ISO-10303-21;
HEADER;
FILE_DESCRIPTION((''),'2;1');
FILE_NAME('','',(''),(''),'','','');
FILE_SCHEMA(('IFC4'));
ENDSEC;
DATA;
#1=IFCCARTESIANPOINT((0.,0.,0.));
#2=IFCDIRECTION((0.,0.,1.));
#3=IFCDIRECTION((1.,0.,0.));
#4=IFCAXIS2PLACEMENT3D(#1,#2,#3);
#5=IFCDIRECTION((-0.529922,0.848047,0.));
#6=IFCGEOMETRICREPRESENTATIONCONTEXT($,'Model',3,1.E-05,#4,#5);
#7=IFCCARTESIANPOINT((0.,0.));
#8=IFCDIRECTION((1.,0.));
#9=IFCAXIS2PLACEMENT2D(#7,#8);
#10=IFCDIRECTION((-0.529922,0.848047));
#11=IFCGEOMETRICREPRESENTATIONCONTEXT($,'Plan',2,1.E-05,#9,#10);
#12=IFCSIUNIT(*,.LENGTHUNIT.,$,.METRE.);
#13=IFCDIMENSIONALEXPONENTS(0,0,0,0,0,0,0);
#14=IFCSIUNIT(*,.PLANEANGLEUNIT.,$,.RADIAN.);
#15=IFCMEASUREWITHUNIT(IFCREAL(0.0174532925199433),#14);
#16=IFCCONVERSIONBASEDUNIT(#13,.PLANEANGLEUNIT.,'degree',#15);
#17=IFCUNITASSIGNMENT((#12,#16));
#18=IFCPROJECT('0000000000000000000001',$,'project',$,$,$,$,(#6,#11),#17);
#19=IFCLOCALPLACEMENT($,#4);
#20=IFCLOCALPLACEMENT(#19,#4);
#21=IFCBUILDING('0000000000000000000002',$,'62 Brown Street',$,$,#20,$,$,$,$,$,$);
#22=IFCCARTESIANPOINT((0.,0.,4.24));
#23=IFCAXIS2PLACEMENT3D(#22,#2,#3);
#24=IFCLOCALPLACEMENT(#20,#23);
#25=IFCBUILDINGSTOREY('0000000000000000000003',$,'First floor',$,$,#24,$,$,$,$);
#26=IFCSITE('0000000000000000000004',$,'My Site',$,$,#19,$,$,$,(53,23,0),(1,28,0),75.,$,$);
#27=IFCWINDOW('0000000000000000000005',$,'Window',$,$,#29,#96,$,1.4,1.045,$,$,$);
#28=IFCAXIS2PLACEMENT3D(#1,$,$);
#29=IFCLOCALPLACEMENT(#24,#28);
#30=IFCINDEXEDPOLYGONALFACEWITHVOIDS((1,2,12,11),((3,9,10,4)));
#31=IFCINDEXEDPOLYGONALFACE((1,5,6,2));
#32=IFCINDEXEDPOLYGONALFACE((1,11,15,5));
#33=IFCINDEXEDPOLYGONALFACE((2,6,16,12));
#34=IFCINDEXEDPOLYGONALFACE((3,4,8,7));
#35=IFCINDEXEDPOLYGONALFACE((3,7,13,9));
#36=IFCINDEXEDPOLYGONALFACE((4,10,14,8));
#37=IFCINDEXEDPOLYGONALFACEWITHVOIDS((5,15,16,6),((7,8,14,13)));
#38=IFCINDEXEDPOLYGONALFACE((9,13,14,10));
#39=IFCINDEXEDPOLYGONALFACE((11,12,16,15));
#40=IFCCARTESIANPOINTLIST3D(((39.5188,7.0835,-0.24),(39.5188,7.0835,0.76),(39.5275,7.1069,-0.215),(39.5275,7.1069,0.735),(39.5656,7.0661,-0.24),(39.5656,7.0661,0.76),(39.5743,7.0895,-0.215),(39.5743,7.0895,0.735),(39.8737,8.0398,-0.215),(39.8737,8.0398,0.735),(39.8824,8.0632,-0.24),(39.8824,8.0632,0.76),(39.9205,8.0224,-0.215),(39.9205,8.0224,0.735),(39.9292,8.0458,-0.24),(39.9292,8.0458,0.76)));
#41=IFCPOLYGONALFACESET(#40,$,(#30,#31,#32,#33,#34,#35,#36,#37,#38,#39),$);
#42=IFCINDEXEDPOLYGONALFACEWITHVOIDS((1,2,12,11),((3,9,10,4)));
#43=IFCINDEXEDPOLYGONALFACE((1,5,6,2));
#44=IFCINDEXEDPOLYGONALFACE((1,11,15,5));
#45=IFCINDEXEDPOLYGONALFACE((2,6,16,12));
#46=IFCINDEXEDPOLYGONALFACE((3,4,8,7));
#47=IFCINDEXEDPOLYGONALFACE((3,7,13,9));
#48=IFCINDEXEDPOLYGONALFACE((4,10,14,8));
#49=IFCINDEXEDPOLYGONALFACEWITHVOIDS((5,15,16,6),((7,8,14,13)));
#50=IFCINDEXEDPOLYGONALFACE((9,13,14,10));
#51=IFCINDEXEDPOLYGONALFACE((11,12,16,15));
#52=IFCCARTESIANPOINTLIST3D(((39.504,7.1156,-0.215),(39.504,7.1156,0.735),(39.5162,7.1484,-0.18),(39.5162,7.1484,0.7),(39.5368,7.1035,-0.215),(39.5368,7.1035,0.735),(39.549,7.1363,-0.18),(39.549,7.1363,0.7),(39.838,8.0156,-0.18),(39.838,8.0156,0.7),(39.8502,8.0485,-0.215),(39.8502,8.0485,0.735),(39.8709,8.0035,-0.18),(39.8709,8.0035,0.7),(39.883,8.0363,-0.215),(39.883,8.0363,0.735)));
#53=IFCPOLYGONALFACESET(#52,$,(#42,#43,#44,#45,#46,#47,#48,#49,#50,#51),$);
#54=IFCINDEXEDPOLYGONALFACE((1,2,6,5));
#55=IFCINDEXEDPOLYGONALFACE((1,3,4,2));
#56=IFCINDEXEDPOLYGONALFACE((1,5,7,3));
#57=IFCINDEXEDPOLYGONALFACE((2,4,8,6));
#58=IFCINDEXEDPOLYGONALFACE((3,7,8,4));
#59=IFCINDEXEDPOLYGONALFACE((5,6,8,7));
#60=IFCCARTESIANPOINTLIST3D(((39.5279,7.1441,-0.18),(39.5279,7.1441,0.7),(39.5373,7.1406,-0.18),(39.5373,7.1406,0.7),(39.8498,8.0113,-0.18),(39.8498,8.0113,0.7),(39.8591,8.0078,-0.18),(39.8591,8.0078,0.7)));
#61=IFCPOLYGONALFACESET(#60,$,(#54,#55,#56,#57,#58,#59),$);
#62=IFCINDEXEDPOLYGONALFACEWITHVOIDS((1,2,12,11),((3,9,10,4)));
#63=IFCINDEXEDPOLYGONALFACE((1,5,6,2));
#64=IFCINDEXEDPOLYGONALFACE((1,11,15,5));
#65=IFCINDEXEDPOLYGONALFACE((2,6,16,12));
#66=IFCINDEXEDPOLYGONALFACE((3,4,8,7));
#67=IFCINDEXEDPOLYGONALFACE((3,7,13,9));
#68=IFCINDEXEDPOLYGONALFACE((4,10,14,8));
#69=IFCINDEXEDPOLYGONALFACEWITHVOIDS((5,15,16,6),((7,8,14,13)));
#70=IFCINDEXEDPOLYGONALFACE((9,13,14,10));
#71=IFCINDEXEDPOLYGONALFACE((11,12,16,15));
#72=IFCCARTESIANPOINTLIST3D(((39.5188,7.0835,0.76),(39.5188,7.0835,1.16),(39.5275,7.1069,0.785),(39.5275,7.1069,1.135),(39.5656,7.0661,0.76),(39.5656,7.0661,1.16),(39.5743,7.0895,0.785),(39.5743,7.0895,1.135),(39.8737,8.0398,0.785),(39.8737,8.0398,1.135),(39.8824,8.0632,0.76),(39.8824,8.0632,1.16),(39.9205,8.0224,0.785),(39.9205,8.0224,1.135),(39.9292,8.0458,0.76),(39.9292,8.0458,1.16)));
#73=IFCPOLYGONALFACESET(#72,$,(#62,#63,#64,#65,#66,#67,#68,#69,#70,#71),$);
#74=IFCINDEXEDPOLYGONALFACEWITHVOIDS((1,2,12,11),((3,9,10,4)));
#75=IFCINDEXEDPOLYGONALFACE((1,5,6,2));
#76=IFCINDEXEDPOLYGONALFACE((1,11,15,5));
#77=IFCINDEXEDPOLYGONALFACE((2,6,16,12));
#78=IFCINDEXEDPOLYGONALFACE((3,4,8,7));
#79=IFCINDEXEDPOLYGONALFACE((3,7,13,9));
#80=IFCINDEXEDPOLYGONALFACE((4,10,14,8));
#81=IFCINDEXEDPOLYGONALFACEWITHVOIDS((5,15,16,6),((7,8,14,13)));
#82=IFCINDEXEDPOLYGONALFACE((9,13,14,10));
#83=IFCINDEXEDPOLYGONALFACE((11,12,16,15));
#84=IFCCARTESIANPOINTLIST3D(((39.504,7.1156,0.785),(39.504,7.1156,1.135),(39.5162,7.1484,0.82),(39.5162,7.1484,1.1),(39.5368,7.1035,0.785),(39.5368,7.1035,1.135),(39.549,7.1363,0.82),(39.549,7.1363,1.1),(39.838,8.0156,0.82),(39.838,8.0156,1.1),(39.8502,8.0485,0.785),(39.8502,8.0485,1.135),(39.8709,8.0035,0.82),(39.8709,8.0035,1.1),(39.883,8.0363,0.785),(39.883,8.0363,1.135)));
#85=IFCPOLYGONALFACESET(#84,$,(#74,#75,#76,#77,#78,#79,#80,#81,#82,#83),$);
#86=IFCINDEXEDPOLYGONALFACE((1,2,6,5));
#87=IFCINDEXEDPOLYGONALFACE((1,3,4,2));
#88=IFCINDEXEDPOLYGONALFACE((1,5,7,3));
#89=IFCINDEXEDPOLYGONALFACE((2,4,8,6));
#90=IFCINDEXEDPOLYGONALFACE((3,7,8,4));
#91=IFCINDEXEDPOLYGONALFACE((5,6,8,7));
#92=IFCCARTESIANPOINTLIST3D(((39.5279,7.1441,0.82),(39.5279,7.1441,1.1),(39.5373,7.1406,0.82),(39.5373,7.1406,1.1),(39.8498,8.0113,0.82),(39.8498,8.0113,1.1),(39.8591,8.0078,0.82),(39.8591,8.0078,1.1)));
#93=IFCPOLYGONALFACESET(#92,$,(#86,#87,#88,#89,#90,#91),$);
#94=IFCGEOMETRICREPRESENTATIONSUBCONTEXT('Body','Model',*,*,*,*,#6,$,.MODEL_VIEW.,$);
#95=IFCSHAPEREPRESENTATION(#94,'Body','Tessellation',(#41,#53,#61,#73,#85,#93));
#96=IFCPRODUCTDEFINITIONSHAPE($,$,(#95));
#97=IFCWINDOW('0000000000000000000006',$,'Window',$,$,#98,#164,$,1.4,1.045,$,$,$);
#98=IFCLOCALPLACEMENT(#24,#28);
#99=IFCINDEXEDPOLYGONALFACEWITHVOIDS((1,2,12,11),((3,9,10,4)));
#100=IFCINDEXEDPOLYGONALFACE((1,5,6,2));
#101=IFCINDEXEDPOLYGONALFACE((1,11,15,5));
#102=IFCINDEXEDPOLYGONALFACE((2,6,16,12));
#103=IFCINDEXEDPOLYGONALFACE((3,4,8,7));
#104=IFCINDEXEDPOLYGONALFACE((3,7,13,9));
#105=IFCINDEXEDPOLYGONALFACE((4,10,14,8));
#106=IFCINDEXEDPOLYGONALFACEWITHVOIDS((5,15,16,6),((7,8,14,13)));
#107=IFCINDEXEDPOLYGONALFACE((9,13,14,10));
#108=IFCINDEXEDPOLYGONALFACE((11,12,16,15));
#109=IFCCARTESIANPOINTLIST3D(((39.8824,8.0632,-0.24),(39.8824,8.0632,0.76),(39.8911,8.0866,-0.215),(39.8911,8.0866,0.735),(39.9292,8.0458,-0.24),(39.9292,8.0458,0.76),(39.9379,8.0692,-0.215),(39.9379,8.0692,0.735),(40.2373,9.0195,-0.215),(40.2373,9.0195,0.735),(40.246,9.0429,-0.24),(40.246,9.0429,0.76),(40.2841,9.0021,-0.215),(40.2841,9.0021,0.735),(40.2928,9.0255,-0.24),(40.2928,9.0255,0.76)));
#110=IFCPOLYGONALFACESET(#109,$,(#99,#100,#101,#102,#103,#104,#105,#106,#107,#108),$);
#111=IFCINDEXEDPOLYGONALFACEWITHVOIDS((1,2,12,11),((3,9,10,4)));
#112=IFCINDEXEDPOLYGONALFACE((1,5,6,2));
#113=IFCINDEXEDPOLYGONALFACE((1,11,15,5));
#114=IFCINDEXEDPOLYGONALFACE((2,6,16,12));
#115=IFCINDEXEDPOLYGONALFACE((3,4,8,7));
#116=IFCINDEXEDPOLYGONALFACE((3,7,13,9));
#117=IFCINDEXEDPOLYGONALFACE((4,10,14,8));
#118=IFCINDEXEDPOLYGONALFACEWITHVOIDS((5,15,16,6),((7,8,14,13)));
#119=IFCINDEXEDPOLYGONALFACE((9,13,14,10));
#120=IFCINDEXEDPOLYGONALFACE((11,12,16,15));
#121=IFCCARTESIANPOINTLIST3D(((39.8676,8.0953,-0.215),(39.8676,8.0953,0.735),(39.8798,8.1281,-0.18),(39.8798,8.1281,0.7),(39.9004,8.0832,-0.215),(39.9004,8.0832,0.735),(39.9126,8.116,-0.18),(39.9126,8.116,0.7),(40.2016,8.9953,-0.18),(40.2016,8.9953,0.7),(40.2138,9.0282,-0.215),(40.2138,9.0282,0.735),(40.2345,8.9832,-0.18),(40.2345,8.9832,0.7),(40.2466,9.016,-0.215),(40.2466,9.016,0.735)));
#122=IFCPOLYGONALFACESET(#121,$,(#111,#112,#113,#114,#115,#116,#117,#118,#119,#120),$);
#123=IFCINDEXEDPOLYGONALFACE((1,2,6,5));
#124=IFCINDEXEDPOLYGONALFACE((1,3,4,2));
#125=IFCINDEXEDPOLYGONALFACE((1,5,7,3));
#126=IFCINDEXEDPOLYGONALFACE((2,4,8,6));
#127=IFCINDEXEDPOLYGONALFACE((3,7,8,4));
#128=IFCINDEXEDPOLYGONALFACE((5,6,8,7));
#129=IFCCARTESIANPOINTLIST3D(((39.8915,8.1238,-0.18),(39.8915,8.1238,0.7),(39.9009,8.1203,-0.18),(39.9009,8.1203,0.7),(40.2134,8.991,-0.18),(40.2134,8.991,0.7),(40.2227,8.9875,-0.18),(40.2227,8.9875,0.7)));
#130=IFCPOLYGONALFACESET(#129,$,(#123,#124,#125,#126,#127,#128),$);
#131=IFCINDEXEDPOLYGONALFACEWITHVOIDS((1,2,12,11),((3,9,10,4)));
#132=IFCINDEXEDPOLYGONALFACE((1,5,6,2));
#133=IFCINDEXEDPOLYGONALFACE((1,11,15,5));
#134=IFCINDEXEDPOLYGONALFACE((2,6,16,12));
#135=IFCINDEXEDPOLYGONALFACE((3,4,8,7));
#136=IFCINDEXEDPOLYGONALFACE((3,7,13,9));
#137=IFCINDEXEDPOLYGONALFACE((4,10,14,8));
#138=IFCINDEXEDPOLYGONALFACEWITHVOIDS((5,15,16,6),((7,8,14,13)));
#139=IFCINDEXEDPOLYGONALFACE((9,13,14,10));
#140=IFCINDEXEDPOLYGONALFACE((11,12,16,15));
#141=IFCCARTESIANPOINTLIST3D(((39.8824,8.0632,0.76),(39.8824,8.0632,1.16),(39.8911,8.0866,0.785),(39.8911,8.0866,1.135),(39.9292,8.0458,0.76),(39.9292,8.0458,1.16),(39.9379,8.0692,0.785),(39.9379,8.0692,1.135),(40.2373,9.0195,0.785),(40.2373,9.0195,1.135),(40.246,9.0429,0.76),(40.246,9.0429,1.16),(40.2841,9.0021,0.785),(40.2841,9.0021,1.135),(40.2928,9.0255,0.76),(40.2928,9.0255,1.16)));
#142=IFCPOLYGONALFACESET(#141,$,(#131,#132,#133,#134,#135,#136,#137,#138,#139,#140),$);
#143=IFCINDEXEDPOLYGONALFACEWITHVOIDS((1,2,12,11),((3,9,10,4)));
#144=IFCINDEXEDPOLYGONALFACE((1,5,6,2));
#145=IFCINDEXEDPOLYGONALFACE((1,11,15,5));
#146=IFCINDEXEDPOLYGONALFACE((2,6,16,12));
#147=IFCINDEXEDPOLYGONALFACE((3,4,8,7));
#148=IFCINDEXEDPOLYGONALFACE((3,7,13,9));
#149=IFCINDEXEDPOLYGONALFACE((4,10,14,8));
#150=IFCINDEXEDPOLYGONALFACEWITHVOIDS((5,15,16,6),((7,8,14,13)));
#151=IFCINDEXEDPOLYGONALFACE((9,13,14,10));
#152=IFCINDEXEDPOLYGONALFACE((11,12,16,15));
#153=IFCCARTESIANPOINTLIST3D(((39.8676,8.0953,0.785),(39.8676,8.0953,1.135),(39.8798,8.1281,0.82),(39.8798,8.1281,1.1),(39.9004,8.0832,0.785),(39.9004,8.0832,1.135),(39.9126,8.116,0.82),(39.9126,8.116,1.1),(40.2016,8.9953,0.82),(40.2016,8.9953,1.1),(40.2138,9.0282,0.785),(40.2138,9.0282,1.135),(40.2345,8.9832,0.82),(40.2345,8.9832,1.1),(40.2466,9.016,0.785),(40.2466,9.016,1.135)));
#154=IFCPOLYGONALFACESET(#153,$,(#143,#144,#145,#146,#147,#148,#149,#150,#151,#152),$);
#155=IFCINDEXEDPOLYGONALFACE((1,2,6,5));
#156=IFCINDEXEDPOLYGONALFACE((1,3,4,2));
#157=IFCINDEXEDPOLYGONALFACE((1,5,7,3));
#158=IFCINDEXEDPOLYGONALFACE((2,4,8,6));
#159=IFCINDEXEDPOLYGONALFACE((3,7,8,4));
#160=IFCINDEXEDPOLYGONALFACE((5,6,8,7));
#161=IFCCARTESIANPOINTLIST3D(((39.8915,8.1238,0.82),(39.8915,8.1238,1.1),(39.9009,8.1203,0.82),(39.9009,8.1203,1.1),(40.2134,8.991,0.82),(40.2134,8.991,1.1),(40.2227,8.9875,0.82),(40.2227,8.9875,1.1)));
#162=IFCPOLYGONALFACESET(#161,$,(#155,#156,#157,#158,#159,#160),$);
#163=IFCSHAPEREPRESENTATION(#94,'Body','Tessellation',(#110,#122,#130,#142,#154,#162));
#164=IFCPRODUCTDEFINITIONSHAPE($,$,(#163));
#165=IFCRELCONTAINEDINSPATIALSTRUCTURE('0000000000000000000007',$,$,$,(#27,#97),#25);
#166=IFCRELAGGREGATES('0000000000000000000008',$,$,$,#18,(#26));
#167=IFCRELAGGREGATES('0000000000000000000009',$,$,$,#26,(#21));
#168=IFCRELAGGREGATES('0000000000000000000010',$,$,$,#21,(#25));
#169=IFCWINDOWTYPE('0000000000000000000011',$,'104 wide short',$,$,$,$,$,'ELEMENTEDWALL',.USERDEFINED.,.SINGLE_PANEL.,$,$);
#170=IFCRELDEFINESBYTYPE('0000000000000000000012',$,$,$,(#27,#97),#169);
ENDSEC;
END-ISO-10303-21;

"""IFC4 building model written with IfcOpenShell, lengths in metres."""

from ifc_helpers import new_model, entity, si_unit, converted_unit, direction, frame, origin_with_axes, origin_2d_with_axis, place, context, subcontext, project, spatial, line, indexed_curve, outline, extrude, shape, source, transform, mapped, type_object, type_shapes, element, save


model = new_model("IFC4")

# Units and contexts
model_context = context("Model", 3, precision=1e-05, world=origin_with_axes(), true_north=direction((-0.529922, 0.848047, 0.0)))
plan_context = context("Plan", 2, precision=1e-05, world=origin_2d_with_axis(), true_north=direction((-0.529922, 0.848047)))
body_context_1 = subcontext(model_context, "Body", "Model", "MODEL_VIEW")
body_context_2 = subcontext(plan_context, "Body", "Plan", "PLAN_VIEW")
ifc_project = project(units=[si_unit("LENGTHUNIT", "METRE"), converted_unit("PLANEANGLEUNIT", "degree", entity("IfcReal", 0.0174532925199433), si_unit("PLANEANGLEUNIT", "RADIAN"), dimensions=[0, 0, 0, 0, 0, 0, 0])], contexts=[model_context, plan_context])

# Site, building, storey
site_placement = place(None, origin_with_axes())
site = spatial("IfcSite", under=ifc_project, at=site_placement, Name="My Site", RefLatitude=(53, 23, 0), RefLongitude=(1, 28, 0), RefElevation=75.0)
building_placement = place(site_placement, origin_with_axes())
building = spatial("IfcBuilding", under=site, at=building_placement, Name="62 Brown Street")
storey_placement = place(building_placement, frame((0.0, 0.0, 4.24), z_axis=(0.0, 0.0, 1.0), x_axis=(1.0, 0.0, 0.0)))
storey = spatial("IfcBuildingStorey", under=building, at=storey_placement, Name="First floor")

# Shared definitions
window_type_1 = type_object("IfcWindowType", Name="104 wide short", ElementType="ELEMENTEDWALL", PartitioningType="SINGLE_PANEL", PredefinedType="USERDEFINED")
shared_shape_1 = source(origin_with_axes(), body_context_1, "Body", "SweptSolid", [
    extrude(outline(indexed_curve([(0.0, 0.0), (1.045, 0.0), (1.045, 1.0), (0.0, 1.0)], segments=[line(1, 2, 3, 4, 1)]), holes=[indexed_curve([(0.025, 0.025), (1.02, 0.025), (1.02, 0.975), (0.025, 0.975)], segments=[line(1, 2, 3, 4, 1)])]), frame((0.0, 0.15, 0.0), z_axis=(0.0, -1.0, 0.0), x_axis=(1.0, 0.0, 0.0)), (0.0, 0.0, -1.0), 0.05),
    extrude(outline(indexed_curve([(0.0, 0.0), (0.995, 0.0), (0.995, 0.95), (0.0, 0.95)], segments=[line(1, 2, 3, 4, 1)]), holes=[indexed_curve([(0.035, 0.035), (0.96, 0.035), (0.96, 0.915), (0.035, 0.915)], segments=[line(1, 2, 3, 4, 1)])]), frame((0.025, 0.19, 0.025), z_axis=(0.0, -1.0, 0.0), x_axis=(1.0, 0.0, 0.0)), (0.0, 0.0, -1.0), 0.035),
    extrude(outline(indexed_curve([(0.035, 0.035), (0.96, 0.035), (0.96, 0.915), (0.035, 0.915)], segments=[line(1, 2, 3, 4, 1)])), frame((0.025, 0.2025, 0.025), z_axis=(0.0, -1.0, 0.0), x_axis=(1.0, 0.0, 0.0)), (0.0, 0.0, -1.0), 0.01),
    extrude(outline(indexed_curve([(0.0, 0.0), (1.045, 0.0), (1.045, 0.4), (0.0, 0.4)], segments=[line(1, 2, 3, 4, 1)]), holes=[indexed_curve([(0.025, 0.025), (1.02, 0.025), (1.02, 0.375), (0.025, 0.375)], segments=[line(1, 2, 3, 4, 1)])]), frame((0.0, 0.15, 1.0), z_axis=(0.0, -1.0, 0.0), x_axis=(1.0, 0.0, 0.0)), (0.0, 0.0, -1.0), 0.05),
    extrude(outline(indexed_curve([(0.0, 0.0), (0.995, 0.0), (0.995, 0.35), (0.0, 0.35)], segments=[line(1, 2, 3, 4, 1)]), holes=[indexed_curve([(0.035, 0.035), (0.96, 0.035), (0.96, 0.315), (0.035, 0.315)], segments=[line(1, 2, 3, 4, 1)])]), frame((0.025, 0.19, 1.025), z_axis=(0.0, -1.0, 0.0), x_axis=(1.0, 0.0, 0.0)), (0.0, 0.0, -1.0), 0.035),
    extrude(outline(indexed_curve([(0.035, 0.035), (0.96, 0.035), (0.96, 0.315), (0.035, 0.315)], segments=[line(1, 2, 3, 4, 1)])), frame((0.025, 0.2025, 1.025), z_axis=(0.0, -1.0, 0.0), x_axis=(1.0, 0.0, 0.0)), (0.0, 0.0, -1.0), 0.01),
])
shared_shape_2 = source(origin_with_axes(), body_context_2, "Body", "Curve2D", [
    entity("IfcIndexedPolyCurve", entity("IfcCartesianPointList2D", [[0.025, 0.15], [1.02, 0.15]])),
    entity("IfcIndexedPolyCurve", entity("IfcCartesianPointList2D", [[0.0, 0.2], [0.025, 0.2], [0.025, 0.15], [0.0, 0.15]]), [entity("IfcLineIndex", [1, 2, 3, 4, 1])]),
    entity("IfcIndexedPolyCurve", entity("IfcCartesianPointList2D", [[1.045, 0.2], [1.02, 0.2], [1.02, 0.15], [1.045, 0.15]]), [entity("IfcLineIndex", [1, 2, 3, 4, 1])]),
    entity("IfcIndexedPolyCurve", entity("IfcCartesianPointList2D", [[0.025, 0.19], [0.06, 0.19], [0.06, 0.225], [0.025, 0.225]]), [entity("IfcLineIndex", [1, 2, 3, 4, 1])]),
    entity("IfcIndexedPolyCurve", entity("IfcCartesianPointList2D", [[1.02, 0.19], [0.985, 0.19], [0.985, 0.225], [1.02, 0.225]]), [entity("IfcLineIndex", [1, 2, 3, 4, 1])]),
    entity("IfcIndexedPolyCurve", entity("IfcCartesianPointList2D", [[0.06, 0.19], [0.985, 0.19]])),
    entity("IfcIndexedPolyCurve", entity("IfcCartesianPointList2D", [[0.06, 0.225], [0.985, 0.225]])),
    entity("IfcIndexedPolyCurve", entity("IfcCartesianPointList2D", [[0.06, 0.2075], [0.985, 0.2075]])),
])
type_shapes(window_type_1, [shared_shape_1, shared_shape_2])

# Windows
for number, where, z_axis, x_axis, name in (
    (1, (39.7063, 7.0139, -0.24), (0.0, 0.0, 1.0), (0.347944, 0.937515, 0.0), "Window"),
    (2, (40.0699, 7.9936, -0.24), (0.0, 0.0, 1.0), (0.347944, 0.937515, 0.0), "Window"),
):
    element("IfcWindow", number, at=place(storey_placement, frame(where, z_axis=z_axis, x_axis=x_axis)), inside=storey, type_object=window_type_1, Name=name, OverallHeight=1.4, OverallWidth=1.045, shapes=[
        shape(body_context_1, "Body", "MappedRepresentation", [mapped(shared_shape_1, transform((0.0, 0.0, 0.0), x_axis=(1.0, 0.0, 0.0), y_axis=(0.0, 1.0, 0.0), z_axis=(0.0, 0.0, 1.0), scale=1.0))]),
        shape(body_context_2, "Body", "MappedRepresentation", [mapped(shared_shape_2, transform((0.0, 0.0, 0.0), x_axis=(1.0, 0.0, 0.0), y_axis=(0.0, 1.0, 0.0), z_axis=(0.0, 0.0, 1.0), scale=1.0))]),
    ])

save(model, "model.ifc")
